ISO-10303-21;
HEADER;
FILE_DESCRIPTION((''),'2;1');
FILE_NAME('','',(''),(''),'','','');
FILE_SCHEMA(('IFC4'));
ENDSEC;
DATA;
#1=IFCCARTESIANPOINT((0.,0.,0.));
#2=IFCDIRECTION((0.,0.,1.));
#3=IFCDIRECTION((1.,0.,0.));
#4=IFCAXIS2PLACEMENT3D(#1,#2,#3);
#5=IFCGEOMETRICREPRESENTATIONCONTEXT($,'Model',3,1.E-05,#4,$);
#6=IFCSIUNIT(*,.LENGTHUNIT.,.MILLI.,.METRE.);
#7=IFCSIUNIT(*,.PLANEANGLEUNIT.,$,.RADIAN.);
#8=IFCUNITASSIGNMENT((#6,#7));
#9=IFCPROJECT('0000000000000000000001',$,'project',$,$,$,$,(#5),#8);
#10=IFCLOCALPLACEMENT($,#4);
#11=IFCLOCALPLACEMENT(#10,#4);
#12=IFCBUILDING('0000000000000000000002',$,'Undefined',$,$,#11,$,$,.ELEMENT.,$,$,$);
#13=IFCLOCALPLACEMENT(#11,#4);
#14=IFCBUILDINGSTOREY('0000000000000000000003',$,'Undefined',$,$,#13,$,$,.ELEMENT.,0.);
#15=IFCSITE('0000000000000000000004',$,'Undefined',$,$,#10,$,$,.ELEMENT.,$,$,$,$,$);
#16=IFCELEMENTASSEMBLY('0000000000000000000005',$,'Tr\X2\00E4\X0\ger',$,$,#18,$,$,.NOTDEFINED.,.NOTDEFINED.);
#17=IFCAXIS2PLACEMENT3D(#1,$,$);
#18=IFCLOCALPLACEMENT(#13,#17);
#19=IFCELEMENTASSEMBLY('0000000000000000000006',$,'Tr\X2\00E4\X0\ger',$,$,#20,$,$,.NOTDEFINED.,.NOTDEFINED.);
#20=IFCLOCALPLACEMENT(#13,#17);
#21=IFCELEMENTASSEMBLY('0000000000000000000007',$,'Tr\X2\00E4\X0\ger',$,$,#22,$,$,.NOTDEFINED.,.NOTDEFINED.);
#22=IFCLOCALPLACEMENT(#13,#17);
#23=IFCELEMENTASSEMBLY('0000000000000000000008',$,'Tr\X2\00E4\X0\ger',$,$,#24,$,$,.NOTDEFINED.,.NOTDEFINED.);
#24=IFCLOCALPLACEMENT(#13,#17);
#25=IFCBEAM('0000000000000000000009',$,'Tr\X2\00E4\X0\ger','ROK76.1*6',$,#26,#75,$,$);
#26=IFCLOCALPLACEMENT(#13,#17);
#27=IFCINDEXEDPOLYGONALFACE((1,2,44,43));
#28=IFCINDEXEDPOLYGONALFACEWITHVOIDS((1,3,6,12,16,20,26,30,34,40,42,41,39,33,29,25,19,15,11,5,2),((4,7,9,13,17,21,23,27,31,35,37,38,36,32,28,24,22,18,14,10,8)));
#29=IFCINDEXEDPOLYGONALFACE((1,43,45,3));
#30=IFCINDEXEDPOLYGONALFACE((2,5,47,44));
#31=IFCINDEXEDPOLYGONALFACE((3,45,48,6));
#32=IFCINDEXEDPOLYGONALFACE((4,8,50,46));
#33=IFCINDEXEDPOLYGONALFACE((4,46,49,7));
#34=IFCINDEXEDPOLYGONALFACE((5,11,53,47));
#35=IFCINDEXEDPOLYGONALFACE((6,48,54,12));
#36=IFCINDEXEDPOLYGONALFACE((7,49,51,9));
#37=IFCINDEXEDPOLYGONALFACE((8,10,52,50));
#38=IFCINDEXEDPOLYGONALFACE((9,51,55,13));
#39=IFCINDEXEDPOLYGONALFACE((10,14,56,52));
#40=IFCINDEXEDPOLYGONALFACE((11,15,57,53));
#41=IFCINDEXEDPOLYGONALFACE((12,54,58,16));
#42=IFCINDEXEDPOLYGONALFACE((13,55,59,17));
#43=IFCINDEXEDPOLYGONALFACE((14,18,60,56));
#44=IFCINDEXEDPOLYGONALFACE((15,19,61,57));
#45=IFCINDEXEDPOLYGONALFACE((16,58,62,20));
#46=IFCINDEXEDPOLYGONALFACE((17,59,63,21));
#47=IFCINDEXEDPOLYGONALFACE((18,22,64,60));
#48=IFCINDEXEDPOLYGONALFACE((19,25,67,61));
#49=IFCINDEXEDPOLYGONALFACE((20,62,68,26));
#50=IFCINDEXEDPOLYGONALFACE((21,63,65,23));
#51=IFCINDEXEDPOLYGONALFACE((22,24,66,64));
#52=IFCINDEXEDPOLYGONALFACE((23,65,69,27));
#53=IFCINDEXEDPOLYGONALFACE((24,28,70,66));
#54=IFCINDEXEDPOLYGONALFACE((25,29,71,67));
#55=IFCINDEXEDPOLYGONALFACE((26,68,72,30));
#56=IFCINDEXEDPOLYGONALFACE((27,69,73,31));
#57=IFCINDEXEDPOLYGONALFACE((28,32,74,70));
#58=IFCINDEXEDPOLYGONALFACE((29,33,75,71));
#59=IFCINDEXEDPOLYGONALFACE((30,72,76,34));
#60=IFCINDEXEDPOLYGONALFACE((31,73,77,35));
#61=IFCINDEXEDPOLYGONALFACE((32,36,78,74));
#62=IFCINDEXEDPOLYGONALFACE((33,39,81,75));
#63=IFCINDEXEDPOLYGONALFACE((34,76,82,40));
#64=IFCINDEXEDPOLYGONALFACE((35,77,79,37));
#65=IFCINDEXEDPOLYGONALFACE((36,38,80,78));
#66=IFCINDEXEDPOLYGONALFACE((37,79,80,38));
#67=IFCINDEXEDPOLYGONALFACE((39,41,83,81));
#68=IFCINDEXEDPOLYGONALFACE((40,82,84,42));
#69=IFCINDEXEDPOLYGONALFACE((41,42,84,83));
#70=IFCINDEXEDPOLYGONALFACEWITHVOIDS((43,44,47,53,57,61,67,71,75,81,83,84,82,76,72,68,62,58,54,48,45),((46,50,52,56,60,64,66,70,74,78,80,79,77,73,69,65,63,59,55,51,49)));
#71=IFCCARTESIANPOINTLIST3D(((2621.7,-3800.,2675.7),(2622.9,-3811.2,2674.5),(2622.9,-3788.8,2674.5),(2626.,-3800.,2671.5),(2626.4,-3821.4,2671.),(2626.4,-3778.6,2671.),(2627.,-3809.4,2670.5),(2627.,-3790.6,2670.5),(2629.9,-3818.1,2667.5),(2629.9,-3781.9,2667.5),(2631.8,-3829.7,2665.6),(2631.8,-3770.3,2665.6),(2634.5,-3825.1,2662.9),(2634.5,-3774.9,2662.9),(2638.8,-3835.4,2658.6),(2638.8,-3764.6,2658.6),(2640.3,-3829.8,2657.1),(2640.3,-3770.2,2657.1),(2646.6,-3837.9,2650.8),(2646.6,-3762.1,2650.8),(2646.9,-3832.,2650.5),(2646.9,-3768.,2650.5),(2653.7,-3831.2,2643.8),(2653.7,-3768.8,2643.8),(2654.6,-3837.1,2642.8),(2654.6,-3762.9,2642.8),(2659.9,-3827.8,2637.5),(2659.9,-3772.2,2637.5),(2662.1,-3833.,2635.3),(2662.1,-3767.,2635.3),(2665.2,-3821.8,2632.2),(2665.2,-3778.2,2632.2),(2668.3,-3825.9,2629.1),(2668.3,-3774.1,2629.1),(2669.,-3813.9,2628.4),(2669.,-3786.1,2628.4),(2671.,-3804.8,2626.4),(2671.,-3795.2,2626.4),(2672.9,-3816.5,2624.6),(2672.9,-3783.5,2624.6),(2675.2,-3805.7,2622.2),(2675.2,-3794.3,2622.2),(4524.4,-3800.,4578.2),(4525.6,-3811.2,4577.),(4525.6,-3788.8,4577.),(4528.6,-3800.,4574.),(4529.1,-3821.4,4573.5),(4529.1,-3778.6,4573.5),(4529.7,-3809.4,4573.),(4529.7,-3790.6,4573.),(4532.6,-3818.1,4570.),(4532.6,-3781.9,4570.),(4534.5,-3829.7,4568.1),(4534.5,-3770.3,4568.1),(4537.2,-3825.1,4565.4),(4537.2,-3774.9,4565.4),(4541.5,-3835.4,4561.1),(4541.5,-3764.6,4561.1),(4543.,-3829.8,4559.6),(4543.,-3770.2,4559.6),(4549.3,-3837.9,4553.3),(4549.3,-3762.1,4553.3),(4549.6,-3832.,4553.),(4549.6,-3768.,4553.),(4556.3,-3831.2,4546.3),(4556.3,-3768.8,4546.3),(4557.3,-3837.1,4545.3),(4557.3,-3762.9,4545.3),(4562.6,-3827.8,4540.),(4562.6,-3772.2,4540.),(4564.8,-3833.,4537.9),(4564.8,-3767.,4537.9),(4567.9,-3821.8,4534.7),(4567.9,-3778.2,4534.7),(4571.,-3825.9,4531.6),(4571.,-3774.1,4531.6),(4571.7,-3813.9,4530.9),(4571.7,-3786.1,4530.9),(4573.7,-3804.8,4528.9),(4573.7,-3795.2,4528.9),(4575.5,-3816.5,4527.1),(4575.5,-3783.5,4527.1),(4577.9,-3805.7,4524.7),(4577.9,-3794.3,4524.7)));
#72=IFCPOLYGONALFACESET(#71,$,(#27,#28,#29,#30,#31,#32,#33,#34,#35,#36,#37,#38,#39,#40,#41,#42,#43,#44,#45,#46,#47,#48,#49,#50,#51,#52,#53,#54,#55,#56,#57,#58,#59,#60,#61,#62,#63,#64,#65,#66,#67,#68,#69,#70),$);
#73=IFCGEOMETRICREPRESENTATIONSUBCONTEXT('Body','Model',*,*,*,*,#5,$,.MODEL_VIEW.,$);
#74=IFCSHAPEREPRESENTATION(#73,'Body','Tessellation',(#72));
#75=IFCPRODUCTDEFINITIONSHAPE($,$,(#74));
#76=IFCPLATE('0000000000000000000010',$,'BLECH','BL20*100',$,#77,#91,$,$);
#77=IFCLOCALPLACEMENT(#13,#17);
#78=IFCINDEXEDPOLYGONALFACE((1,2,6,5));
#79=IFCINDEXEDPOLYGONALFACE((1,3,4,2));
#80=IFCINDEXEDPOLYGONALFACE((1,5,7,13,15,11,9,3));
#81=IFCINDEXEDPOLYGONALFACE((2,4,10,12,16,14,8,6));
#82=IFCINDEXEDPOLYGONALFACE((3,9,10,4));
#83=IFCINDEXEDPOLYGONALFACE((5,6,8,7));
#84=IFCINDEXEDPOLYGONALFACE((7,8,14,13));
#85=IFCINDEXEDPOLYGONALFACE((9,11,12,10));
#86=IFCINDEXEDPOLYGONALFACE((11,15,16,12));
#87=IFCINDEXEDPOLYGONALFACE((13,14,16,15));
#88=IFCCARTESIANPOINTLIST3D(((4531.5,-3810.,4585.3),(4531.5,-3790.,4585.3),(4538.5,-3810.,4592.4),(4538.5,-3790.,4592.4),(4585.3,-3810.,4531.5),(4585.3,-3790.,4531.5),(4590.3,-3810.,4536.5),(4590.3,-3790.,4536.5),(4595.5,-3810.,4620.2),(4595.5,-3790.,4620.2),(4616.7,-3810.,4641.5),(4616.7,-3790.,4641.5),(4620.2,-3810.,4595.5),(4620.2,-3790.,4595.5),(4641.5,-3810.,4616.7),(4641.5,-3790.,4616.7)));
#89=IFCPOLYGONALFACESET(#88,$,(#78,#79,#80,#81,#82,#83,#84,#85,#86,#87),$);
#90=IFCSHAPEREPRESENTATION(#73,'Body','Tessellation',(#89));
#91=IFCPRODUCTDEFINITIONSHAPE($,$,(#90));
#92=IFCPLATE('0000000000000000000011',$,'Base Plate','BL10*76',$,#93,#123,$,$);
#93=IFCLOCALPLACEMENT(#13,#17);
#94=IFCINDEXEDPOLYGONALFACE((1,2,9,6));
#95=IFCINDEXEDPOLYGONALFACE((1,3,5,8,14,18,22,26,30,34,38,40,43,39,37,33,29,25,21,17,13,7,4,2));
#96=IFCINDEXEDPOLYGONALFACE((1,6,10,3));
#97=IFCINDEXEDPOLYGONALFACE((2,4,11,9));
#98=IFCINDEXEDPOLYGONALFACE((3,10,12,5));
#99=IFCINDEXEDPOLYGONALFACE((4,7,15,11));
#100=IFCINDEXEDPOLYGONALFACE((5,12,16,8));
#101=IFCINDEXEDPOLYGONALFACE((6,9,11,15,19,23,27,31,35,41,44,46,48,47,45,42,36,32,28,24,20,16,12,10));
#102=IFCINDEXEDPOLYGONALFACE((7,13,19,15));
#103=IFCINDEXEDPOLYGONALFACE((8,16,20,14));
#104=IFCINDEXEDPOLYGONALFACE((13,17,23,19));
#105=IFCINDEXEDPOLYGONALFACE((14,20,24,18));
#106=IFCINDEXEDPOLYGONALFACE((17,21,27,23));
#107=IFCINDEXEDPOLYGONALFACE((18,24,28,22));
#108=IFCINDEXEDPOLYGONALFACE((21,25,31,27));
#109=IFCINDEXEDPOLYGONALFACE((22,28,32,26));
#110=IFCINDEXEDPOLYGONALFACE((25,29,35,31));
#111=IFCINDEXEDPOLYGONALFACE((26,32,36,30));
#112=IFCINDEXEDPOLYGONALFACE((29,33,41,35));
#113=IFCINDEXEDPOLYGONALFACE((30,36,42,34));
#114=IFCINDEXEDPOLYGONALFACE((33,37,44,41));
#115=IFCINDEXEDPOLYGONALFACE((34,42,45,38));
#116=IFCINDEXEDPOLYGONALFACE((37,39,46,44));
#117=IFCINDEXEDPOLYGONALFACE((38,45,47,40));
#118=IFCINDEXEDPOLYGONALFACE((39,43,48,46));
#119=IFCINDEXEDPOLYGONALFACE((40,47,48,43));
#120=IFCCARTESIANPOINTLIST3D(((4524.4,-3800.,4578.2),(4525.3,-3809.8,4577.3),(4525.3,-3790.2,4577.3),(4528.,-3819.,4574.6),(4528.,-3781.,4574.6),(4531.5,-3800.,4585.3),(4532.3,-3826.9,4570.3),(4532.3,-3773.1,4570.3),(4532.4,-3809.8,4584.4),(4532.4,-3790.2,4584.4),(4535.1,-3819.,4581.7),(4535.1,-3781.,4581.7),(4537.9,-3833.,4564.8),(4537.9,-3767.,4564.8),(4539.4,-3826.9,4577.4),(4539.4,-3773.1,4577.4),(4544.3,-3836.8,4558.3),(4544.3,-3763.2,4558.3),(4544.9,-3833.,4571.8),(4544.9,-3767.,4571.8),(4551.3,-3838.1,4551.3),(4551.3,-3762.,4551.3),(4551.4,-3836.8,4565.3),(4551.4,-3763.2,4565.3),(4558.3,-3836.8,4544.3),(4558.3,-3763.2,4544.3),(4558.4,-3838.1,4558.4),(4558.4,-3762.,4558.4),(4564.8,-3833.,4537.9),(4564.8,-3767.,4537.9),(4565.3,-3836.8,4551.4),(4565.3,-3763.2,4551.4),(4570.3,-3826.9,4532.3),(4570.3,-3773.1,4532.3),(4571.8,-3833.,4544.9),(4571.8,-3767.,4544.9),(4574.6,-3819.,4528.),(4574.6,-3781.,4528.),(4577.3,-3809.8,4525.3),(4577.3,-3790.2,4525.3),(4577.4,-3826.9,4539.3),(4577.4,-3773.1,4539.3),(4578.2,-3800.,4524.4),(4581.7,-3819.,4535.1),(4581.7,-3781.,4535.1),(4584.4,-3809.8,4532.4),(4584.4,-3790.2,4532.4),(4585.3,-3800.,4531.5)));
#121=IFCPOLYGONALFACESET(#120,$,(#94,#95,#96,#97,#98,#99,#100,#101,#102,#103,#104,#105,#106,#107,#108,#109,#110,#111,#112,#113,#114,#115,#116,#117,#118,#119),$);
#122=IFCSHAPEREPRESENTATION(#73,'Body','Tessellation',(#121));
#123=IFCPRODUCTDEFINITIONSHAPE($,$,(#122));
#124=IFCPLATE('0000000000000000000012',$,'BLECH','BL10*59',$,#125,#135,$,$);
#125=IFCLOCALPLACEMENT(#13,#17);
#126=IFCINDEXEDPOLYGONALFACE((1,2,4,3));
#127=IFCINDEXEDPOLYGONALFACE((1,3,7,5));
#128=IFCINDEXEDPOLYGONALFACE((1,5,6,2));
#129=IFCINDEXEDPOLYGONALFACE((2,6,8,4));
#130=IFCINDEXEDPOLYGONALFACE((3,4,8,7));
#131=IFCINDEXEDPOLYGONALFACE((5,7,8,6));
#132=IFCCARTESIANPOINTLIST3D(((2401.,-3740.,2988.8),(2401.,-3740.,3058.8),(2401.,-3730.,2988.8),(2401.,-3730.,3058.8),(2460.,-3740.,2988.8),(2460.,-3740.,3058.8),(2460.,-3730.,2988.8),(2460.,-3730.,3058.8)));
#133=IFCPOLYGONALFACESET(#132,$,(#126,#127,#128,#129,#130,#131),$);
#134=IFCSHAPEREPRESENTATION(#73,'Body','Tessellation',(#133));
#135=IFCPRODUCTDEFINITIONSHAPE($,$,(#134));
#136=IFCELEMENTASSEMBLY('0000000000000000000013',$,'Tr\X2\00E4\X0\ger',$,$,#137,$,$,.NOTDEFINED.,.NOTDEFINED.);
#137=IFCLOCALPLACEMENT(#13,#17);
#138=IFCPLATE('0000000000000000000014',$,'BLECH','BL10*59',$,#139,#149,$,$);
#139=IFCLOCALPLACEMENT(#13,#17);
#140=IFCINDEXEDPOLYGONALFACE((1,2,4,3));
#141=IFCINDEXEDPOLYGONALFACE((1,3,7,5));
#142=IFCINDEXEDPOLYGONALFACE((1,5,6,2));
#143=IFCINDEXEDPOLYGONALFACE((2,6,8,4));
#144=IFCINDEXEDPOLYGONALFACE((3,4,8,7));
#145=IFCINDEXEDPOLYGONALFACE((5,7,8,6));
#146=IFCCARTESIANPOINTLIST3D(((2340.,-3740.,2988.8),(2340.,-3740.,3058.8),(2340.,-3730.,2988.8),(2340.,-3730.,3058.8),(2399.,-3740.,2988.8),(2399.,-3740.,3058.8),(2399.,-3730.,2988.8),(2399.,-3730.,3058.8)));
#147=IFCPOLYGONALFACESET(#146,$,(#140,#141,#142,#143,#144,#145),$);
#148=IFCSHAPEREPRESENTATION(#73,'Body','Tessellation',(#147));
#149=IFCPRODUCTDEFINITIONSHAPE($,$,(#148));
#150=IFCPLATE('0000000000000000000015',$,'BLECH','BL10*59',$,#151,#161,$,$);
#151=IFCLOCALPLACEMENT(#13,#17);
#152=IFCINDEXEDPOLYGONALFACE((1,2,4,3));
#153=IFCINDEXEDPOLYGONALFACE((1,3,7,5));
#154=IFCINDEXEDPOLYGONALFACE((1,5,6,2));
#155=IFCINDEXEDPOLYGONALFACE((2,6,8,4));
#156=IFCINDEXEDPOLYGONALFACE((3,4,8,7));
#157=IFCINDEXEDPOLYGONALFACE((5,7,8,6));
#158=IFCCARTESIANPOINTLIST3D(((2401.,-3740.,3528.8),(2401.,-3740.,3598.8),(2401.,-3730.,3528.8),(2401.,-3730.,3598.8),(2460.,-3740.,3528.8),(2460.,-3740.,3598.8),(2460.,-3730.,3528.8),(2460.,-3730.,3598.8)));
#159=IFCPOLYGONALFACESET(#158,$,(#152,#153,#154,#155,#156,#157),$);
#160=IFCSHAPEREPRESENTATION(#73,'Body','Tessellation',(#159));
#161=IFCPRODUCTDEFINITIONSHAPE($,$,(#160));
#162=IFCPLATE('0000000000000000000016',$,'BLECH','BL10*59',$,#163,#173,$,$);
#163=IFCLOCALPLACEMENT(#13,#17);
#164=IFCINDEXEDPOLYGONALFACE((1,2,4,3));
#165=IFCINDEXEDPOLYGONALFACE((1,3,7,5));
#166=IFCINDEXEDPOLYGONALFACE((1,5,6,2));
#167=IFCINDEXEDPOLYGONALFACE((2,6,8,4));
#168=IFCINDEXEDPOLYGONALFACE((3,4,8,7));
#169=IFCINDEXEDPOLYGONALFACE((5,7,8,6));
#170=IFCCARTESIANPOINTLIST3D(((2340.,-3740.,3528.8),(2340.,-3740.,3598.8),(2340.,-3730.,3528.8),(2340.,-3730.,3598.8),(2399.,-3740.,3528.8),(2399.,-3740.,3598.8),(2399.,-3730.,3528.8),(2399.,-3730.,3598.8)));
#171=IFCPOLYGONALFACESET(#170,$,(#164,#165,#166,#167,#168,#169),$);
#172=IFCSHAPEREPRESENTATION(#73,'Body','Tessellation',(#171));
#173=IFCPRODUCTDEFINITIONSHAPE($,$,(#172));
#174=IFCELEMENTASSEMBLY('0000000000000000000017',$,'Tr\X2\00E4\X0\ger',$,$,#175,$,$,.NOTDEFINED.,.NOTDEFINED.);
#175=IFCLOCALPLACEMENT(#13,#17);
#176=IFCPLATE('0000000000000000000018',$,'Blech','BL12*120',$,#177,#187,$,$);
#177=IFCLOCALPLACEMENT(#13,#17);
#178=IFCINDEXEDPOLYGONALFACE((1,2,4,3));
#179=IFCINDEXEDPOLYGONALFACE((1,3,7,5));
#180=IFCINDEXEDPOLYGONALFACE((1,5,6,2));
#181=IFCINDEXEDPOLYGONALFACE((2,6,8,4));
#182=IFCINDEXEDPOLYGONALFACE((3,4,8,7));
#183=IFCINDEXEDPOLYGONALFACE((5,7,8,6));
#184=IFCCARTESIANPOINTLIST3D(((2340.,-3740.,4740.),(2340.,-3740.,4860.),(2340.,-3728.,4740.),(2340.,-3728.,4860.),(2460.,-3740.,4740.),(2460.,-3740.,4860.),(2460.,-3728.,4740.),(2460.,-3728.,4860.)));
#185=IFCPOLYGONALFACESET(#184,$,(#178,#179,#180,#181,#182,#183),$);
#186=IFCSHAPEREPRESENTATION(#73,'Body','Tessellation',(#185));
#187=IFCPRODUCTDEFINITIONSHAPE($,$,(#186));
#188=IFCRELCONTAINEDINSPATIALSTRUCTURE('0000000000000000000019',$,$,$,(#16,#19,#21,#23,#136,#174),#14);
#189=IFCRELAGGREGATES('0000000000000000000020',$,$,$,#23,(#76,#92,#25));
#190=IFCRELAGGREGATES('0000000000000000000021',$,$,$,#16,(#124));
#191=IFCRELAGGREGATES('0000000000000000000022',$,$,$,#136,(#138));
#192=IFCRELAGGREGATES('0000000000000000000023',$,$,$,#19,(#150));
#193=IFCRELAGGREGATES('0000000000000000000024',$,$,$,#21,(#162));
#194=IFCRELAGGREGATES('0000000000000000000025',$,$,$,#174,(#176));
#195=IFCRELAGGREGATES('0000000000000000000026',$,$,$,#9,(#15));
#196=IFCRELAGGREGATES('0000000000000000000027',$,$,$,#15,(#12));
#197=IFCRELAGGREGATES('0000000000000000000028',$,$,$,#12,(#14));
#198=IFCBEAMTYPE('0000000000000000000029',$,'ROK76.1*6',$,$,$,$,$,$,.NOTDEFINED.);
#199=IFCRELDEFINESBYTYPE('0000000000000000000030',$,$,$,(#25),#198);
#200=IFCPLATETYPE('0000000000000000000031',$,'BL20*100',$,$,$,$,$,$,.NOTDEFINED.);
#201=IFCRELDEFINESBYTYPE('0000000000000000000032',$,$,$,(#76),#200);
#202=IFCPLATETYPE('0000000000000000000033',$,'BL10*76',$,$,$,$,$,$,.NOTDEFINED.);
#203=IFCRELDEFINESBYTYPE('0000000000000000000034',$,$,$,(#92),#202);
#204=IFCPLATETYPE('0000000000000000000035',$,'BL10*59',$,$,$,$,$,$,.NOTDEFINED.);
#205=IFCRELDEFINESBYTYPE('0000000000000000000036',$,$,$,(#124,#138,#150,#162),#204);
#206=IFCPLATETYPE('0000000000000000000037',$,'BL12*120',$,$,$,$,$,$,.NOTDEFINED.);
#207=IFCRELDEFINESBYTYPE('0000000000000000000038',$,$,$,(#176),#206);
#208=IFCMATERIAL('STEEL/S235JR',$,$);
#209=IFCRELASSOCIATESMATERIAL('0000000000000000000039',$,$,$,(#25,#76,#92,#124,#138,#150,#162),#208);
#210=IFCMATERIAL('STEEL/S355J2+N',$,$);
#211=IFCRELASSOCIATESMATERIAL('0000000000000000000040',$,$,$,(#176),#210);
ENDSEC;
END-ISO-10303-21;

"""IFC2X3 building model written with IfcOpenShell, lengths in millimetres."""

from ifc_helpers import new_model, si_unit, frame, frame_2d, origin_with_axes, origin_2d_with_axis, place, context, subcontext, project, spatial, polyline, circle_curve, parameter, trimmed, segment, composite_curve, hollow_circle, outline, extrude, clip, halfspace, material, type_object, element, aggregate, save


model = new_model("IFC2X3")

# Units and contexts
model_context = context("Model", 3, precision=1e-05, world=origin_with_axes())
body_context = subcontext(model_context, "Body", "Model", "MODEL_VIEW")
ifc_project = project(units=[si_unit("LENGTHUNIT", "METRE", prefix="MILLI"), si_unit("PLANEANGLEUNIT", "RADIAN")], contexts=[model_context])

# Site, building, storey
site_placement = place(None, origin_with_axes())
site = spatial("IfcSite", under=ifc_project, at=site_placement, Name="Undefined", CompositionType="ELEMENT")
building_placement = place(site_placement, origin_with_axes())
building = spatial("IfcBuilding", under=site, at=building_placement, Name="Undefined", CompositionType="ELEMENT")
storey_placement = place(building_placement, origin_with_axes())
storey = spatial("IfcBuildingStorey", under=building, at=storey_placement, Name="Undefined", CompositionType="ELEMENT", Elevation=0.0)

# Shared definitions
ifc_material_1 = material(Name="STEEL/S235JR")

# Element assembly
assembly_1_placement = place(storey_placement, origin_with_axes())
assembly_1 = element("IfcElementAssembly", 1, at=assembly_1_placement, inside=storey, Name="Träger", AssemblyPlace="NOTDEFINED", PredefinedType="NOTDEFINED")

# Element assembly
assembly_2_placement = place(storey_placement, origin_with_axes())
assembly_2 = element("IfcElementAssembly", 2, at=assembly_2_placement, inside=storey, Name="Träger", AssemblyPlace="NOTDEFINED", PredefinedType="NOTDEFINED")

# Element assemblies, beam
assembly_3_placement = place(storey_placement, origin_with_axes())
assembly_3 = element("IfcElementAssembly", 3, at=assembly_3_placement, inside=storey, Name="Träger", AssemblyPlace="NOTDEFINED", PredefinedType="NOTDEFINED")
assembly_4_placement = place(storey_placement, origin_with_axes())
assembly_4 = element("IfcElementAssembly", 4, at=assembly_4_placement, inside=storey, Name="Träger", AssemblyPlace="NOTDEFINED", PredefinedType="NOTDEFINED")
beam_type_1 = type_object("IfcBeamType", Name="ROK76.1*6", PredefinedType="NOTDEFINED")
beam_1_placement = place(assembly_4_placement, frame((4544.2, -3800.0, 4544.2), z_axis=(0.0, -1.0, 0.0), x_axis=(-0.707141, 0.0, -0.707072)))
beam_1 = element("IfcBeam", 5, at=beam_1_placement, type_object=beam_type_1, material=ifc_material_1, Name="Träger", Description="ROK76.1*6", context=body_context, shape_type="Clipping", body=[
    clip(extrude(hollow_circle(Radius=38.0, WallThickness=6.0, at=origin_2d_with_axis()), frame((2680.7, 0.0, 0.0), z_axis=(-1.0, 0.0, 0.0), x_axis=(0.0, -1.0, 0.0)), (0.0, 0.0, 1.0), 2767.5), halfspace(frame((-10.0, -38.1, 38.1), z_axis=(-1.0, 0.0, 0.0), x_axis=(0.0, -1.0, 0.0)), False)),
])

# Plates
plate_type_1 = type_object("IfcPlateType", Name="BL20*100", PredefinedType="NOTDEFINED")
plate_1_placement = place(assembly_4_placement, frame((4538.5, -3800.0, 4592.4), z_axis=(0.0, -1.0, 0.0), x_axis=(-0.707141, 0.0, -0.707072)))
plate_1 = element("IfcPlate", 6, at=plate_1_placement, type_object=plate_type_1, material=ifc_material_1, Name="BLECH", Description="BL20*100", context=body_context, shape_type="SweptSolid", body=[
    extrude(outline(polyline([(0.0, 0.0), (10.0, 0.0), (10.0, 76.1), (2.9, 76.1), (-60.0, 55.5), (-90.0, 55.5), (-90.0, 20.5), (-60.0, 20.5), (0.0, 0.0)])), frame((0.0, 0.0, -10.0), z_axis=(0.0, 0.0, 1.0), x_axis=(1.0, 0.0, 0.0)), (0.0, 0.0, 1.0), 20.0),
])
plate_type_2 = type_object("IfcPlateType", Name="BL10*76", PredefinedType="NOTDEFINED")
plate_2_placement = place(assembly_4_placement, frame((4581.7, -3838.1, 4527.9), z_axis=(-0.707141, 0.0, -0.707072), x_axis=(-0.707072, 0.0, 0.707141)))
plate_2 = element("IfcPlate", 7, at=plate_2_placement, type_object=plate_type_2, material=ifc_material_1, Name="Base Plate", Description="BL10*76", context=body_context, shape_type="SweptSolid", body=[
    extrude(outline(composite_curve([segment(trimmed(circle_curve(frame_2d((38.0, 38.0), x_axis=(-1.0, 0.0)), 38.0), [parameter(0.0)], [parameter(1.570796)], True, "PARAMETER"), True, "CONTINUOUS"), segment(trimmed(circle_curve(frame_2d((38.0, 38.0), x_axis=(0.0, -1.0)), 38.0), [parameter(0.0)], [parameter(1.570796)], True, "PARAMETER"), True, "CONTINUOUS"), segment(trimmed(circle_curve(frame_2d((38.0, 38.0), x_axis=(1.0, 0.0)), 38.0), [parameter(0.0)], [parameter(1.570796)], True, "PARAMETER"), True, "CONTINUOUS"), segment(trimmed(circle_curve(frame_2d((38.0, 38.0), x_axis=(0.0, 1.0)), 38.0), [parameter(0.0)], [parameter(1.570796)], True, "PARAMETER"), True, "CONTINUOUS")], self_intersect=True)), frame((0.0, 0.0, -5.0), z_axis=(0.0, 0.0, 1.0), x_axis=(1.0, 0.0, 0.0)), (0.0, 0.0, 1.0), 10.0),
])
aggregate(assembly_4, [plate_1, plate_2, beam_1])
plate_type_3 = type_object("IfcPlateType", Name="BL10*59", PredefinedType="NOTDEFINED")
plate_3_placement = place(assembly_1_placement, frame((2401.0, -3735.0, 3058.8), z_axis=(0.0, 1.0, 0.0), x_axis=(1.0, 0.0, 0.0)))
plate_3 = element("IfcPlate", 8, at=plate_3_placement, type_object=plate_type_3, material=ifc_material_1, Name="BLECH", Description="BL10*59", context=body_context, shape_type="SweptSolid", body=[
    extrude(outline(polyline([(0.0, 0.0), (59.0, 0.0), (59.0, 70.0), (0.0, 70.0), (0.0, 0.0)])), frame((0.0, 0.0, -5.0), z_axis=(0.0, 0.0, 1.0), x_axis=(1.0, 0.0, 0.0)), (0.0, 0.0, 1.0), 10.0),
])
aggregate(assembly_1, [plate_3])

# Element assembly, plate
assembly_5_placement = place(storey_placement, origin_with_axes())
assembly_5 = element("IfcElementAssembly", 9, at=assembly_5_placement, inside=storey, Name="Träger", AssemblyPlace="NOTDEFINED", PredefinedType="NOTDEFINED")
plate_4_placement = place(assembly_5_placement, frame((2399.0, -3735.0, 3058.8), z_axis=(0.0, -1.0, 0.0), x_axis=(-1.0, 0.0, 0.0)))
plate_4 = element("IfcPlate", 10, at=plate_4_placement, type_object=plate_type_3, material=ifc_material_1, Name="BLECH", Description="BL10*59", context=body_context, shape_type="SweptSolid", body=[
    extrude(outline(polyline([(0.0, 0.0), (59.0, 0.0), (59.0, 70.0), (0.0, 70.0), (0.0, 0.0)])), frame((0.0, 0.0, -5.0), z_axis=(0.0, 0.0, 1.0), x_axis=(1.0, 0.0, 0.0)), (0.0, 0.0, 1.0), 10.0),
])
aggregate(assembly_5, [plate_4])

# Plates
plate_5_placement = place(assembly_2_placement, frame((2401.0, -3735.0, 3598.8), z_axis=(0.0, 1.0, 0.0), x_axis=(1.0, 0.0, 0.0)))
plate_5 = element("IfcPlate", 11, at=plate_5_placement, type_object=plate_type_3, material=ifc_material_1, Name="BLECH", Description="BL10*59", context=body_context, shape_type="SweptSolid", body=[
    extrude(outline(polyline([(0.0, 0.0), (59.0, 0.0), (59.0, 70.0), (0.0, 70.0), (0.0, 0.0)])), frame((0.0, 0.0, -5.0), z_axis=(0.0, 0.0, 1.0), x_axis=(1.0, 0.0, 0.0)), (0.0, 0.0, 1.0), 10.0),
])
aggregate(assembly_2, [plate_5])
plate_6_placement = place(assembly_3_placement, frame((2399.0, -3735.0, 3598.8), z_axis=(0.0, -1.0, 0.0), x_axis=(-1.0, 0.0, 0.0)))
plate_6 = element("IfcPlate", 12, at=plate_6_placement, type_object=plate_type_3, material=ifc_material_1, Name="BLECH", Description="BL10*59", context=body_context, shape_type="SweptSolid", body=[
    extrude(outline(polyline([(0.0, 0.0), (59.0, 0.0), (59.0, 70.0), (0.0, 70.0), (0.0, 0.0)])), frame((0.0, 0.0, -5.0), z_axis=(0.0, 0.0, 1.0), x_axis=(1.0, 0.0, 0.0)), (0.0, 0.0, 1.0), 10.0),
])
aggregate(assembly_3, [plate_6])

# Element assembly, plate
assembly_6_placement = place(storey_placement, origin_with_axes())
assembly_6 = element("IfcElementAssembly", 13, at=assembly_6_placement, inside=storey, Name="Träger", AssemblyPlace="NOTDEFINED", PredefinedType="NOTDEFINED")
ifc_material_2 = material(Name="STEEL/S355J2+N")
plate_type_4 = type_object("IfcPlateType", Name="BL12*120", PredefinedType="NOTDEFINED")
plate_7_placement = place(assembly_6_placement, frame((2400.0, -3734.0, 4740.0), z_axis=(0.0, 1.0, 0.0), x_axis=(0.0, 0.0, 1.0)))
plate_7 = element("IfcPlate", 14, at=plate_7_placement, type_object=plate_type_4, material=ifc_material_2, Name="Blech", Description="BL12*120", context=body_context, shape_type="SweptSolid", body=[
    extrude(outline(polyline([(0.0, -60.0), (0.0, 60.0), (120.0, 60.0), (120.0, -60.0), (0.0, -60.0)])), frame((0.0, 0.0, -6.0), z_axis=(0.0, 0.0, 1.0), x_axis=(1.0, 0.0, 0.0)), (0.0, 0.0, 1.0), 12.0),
])
aggregate(assembly_6, [plate_7])

save(model, "model.ifc")
